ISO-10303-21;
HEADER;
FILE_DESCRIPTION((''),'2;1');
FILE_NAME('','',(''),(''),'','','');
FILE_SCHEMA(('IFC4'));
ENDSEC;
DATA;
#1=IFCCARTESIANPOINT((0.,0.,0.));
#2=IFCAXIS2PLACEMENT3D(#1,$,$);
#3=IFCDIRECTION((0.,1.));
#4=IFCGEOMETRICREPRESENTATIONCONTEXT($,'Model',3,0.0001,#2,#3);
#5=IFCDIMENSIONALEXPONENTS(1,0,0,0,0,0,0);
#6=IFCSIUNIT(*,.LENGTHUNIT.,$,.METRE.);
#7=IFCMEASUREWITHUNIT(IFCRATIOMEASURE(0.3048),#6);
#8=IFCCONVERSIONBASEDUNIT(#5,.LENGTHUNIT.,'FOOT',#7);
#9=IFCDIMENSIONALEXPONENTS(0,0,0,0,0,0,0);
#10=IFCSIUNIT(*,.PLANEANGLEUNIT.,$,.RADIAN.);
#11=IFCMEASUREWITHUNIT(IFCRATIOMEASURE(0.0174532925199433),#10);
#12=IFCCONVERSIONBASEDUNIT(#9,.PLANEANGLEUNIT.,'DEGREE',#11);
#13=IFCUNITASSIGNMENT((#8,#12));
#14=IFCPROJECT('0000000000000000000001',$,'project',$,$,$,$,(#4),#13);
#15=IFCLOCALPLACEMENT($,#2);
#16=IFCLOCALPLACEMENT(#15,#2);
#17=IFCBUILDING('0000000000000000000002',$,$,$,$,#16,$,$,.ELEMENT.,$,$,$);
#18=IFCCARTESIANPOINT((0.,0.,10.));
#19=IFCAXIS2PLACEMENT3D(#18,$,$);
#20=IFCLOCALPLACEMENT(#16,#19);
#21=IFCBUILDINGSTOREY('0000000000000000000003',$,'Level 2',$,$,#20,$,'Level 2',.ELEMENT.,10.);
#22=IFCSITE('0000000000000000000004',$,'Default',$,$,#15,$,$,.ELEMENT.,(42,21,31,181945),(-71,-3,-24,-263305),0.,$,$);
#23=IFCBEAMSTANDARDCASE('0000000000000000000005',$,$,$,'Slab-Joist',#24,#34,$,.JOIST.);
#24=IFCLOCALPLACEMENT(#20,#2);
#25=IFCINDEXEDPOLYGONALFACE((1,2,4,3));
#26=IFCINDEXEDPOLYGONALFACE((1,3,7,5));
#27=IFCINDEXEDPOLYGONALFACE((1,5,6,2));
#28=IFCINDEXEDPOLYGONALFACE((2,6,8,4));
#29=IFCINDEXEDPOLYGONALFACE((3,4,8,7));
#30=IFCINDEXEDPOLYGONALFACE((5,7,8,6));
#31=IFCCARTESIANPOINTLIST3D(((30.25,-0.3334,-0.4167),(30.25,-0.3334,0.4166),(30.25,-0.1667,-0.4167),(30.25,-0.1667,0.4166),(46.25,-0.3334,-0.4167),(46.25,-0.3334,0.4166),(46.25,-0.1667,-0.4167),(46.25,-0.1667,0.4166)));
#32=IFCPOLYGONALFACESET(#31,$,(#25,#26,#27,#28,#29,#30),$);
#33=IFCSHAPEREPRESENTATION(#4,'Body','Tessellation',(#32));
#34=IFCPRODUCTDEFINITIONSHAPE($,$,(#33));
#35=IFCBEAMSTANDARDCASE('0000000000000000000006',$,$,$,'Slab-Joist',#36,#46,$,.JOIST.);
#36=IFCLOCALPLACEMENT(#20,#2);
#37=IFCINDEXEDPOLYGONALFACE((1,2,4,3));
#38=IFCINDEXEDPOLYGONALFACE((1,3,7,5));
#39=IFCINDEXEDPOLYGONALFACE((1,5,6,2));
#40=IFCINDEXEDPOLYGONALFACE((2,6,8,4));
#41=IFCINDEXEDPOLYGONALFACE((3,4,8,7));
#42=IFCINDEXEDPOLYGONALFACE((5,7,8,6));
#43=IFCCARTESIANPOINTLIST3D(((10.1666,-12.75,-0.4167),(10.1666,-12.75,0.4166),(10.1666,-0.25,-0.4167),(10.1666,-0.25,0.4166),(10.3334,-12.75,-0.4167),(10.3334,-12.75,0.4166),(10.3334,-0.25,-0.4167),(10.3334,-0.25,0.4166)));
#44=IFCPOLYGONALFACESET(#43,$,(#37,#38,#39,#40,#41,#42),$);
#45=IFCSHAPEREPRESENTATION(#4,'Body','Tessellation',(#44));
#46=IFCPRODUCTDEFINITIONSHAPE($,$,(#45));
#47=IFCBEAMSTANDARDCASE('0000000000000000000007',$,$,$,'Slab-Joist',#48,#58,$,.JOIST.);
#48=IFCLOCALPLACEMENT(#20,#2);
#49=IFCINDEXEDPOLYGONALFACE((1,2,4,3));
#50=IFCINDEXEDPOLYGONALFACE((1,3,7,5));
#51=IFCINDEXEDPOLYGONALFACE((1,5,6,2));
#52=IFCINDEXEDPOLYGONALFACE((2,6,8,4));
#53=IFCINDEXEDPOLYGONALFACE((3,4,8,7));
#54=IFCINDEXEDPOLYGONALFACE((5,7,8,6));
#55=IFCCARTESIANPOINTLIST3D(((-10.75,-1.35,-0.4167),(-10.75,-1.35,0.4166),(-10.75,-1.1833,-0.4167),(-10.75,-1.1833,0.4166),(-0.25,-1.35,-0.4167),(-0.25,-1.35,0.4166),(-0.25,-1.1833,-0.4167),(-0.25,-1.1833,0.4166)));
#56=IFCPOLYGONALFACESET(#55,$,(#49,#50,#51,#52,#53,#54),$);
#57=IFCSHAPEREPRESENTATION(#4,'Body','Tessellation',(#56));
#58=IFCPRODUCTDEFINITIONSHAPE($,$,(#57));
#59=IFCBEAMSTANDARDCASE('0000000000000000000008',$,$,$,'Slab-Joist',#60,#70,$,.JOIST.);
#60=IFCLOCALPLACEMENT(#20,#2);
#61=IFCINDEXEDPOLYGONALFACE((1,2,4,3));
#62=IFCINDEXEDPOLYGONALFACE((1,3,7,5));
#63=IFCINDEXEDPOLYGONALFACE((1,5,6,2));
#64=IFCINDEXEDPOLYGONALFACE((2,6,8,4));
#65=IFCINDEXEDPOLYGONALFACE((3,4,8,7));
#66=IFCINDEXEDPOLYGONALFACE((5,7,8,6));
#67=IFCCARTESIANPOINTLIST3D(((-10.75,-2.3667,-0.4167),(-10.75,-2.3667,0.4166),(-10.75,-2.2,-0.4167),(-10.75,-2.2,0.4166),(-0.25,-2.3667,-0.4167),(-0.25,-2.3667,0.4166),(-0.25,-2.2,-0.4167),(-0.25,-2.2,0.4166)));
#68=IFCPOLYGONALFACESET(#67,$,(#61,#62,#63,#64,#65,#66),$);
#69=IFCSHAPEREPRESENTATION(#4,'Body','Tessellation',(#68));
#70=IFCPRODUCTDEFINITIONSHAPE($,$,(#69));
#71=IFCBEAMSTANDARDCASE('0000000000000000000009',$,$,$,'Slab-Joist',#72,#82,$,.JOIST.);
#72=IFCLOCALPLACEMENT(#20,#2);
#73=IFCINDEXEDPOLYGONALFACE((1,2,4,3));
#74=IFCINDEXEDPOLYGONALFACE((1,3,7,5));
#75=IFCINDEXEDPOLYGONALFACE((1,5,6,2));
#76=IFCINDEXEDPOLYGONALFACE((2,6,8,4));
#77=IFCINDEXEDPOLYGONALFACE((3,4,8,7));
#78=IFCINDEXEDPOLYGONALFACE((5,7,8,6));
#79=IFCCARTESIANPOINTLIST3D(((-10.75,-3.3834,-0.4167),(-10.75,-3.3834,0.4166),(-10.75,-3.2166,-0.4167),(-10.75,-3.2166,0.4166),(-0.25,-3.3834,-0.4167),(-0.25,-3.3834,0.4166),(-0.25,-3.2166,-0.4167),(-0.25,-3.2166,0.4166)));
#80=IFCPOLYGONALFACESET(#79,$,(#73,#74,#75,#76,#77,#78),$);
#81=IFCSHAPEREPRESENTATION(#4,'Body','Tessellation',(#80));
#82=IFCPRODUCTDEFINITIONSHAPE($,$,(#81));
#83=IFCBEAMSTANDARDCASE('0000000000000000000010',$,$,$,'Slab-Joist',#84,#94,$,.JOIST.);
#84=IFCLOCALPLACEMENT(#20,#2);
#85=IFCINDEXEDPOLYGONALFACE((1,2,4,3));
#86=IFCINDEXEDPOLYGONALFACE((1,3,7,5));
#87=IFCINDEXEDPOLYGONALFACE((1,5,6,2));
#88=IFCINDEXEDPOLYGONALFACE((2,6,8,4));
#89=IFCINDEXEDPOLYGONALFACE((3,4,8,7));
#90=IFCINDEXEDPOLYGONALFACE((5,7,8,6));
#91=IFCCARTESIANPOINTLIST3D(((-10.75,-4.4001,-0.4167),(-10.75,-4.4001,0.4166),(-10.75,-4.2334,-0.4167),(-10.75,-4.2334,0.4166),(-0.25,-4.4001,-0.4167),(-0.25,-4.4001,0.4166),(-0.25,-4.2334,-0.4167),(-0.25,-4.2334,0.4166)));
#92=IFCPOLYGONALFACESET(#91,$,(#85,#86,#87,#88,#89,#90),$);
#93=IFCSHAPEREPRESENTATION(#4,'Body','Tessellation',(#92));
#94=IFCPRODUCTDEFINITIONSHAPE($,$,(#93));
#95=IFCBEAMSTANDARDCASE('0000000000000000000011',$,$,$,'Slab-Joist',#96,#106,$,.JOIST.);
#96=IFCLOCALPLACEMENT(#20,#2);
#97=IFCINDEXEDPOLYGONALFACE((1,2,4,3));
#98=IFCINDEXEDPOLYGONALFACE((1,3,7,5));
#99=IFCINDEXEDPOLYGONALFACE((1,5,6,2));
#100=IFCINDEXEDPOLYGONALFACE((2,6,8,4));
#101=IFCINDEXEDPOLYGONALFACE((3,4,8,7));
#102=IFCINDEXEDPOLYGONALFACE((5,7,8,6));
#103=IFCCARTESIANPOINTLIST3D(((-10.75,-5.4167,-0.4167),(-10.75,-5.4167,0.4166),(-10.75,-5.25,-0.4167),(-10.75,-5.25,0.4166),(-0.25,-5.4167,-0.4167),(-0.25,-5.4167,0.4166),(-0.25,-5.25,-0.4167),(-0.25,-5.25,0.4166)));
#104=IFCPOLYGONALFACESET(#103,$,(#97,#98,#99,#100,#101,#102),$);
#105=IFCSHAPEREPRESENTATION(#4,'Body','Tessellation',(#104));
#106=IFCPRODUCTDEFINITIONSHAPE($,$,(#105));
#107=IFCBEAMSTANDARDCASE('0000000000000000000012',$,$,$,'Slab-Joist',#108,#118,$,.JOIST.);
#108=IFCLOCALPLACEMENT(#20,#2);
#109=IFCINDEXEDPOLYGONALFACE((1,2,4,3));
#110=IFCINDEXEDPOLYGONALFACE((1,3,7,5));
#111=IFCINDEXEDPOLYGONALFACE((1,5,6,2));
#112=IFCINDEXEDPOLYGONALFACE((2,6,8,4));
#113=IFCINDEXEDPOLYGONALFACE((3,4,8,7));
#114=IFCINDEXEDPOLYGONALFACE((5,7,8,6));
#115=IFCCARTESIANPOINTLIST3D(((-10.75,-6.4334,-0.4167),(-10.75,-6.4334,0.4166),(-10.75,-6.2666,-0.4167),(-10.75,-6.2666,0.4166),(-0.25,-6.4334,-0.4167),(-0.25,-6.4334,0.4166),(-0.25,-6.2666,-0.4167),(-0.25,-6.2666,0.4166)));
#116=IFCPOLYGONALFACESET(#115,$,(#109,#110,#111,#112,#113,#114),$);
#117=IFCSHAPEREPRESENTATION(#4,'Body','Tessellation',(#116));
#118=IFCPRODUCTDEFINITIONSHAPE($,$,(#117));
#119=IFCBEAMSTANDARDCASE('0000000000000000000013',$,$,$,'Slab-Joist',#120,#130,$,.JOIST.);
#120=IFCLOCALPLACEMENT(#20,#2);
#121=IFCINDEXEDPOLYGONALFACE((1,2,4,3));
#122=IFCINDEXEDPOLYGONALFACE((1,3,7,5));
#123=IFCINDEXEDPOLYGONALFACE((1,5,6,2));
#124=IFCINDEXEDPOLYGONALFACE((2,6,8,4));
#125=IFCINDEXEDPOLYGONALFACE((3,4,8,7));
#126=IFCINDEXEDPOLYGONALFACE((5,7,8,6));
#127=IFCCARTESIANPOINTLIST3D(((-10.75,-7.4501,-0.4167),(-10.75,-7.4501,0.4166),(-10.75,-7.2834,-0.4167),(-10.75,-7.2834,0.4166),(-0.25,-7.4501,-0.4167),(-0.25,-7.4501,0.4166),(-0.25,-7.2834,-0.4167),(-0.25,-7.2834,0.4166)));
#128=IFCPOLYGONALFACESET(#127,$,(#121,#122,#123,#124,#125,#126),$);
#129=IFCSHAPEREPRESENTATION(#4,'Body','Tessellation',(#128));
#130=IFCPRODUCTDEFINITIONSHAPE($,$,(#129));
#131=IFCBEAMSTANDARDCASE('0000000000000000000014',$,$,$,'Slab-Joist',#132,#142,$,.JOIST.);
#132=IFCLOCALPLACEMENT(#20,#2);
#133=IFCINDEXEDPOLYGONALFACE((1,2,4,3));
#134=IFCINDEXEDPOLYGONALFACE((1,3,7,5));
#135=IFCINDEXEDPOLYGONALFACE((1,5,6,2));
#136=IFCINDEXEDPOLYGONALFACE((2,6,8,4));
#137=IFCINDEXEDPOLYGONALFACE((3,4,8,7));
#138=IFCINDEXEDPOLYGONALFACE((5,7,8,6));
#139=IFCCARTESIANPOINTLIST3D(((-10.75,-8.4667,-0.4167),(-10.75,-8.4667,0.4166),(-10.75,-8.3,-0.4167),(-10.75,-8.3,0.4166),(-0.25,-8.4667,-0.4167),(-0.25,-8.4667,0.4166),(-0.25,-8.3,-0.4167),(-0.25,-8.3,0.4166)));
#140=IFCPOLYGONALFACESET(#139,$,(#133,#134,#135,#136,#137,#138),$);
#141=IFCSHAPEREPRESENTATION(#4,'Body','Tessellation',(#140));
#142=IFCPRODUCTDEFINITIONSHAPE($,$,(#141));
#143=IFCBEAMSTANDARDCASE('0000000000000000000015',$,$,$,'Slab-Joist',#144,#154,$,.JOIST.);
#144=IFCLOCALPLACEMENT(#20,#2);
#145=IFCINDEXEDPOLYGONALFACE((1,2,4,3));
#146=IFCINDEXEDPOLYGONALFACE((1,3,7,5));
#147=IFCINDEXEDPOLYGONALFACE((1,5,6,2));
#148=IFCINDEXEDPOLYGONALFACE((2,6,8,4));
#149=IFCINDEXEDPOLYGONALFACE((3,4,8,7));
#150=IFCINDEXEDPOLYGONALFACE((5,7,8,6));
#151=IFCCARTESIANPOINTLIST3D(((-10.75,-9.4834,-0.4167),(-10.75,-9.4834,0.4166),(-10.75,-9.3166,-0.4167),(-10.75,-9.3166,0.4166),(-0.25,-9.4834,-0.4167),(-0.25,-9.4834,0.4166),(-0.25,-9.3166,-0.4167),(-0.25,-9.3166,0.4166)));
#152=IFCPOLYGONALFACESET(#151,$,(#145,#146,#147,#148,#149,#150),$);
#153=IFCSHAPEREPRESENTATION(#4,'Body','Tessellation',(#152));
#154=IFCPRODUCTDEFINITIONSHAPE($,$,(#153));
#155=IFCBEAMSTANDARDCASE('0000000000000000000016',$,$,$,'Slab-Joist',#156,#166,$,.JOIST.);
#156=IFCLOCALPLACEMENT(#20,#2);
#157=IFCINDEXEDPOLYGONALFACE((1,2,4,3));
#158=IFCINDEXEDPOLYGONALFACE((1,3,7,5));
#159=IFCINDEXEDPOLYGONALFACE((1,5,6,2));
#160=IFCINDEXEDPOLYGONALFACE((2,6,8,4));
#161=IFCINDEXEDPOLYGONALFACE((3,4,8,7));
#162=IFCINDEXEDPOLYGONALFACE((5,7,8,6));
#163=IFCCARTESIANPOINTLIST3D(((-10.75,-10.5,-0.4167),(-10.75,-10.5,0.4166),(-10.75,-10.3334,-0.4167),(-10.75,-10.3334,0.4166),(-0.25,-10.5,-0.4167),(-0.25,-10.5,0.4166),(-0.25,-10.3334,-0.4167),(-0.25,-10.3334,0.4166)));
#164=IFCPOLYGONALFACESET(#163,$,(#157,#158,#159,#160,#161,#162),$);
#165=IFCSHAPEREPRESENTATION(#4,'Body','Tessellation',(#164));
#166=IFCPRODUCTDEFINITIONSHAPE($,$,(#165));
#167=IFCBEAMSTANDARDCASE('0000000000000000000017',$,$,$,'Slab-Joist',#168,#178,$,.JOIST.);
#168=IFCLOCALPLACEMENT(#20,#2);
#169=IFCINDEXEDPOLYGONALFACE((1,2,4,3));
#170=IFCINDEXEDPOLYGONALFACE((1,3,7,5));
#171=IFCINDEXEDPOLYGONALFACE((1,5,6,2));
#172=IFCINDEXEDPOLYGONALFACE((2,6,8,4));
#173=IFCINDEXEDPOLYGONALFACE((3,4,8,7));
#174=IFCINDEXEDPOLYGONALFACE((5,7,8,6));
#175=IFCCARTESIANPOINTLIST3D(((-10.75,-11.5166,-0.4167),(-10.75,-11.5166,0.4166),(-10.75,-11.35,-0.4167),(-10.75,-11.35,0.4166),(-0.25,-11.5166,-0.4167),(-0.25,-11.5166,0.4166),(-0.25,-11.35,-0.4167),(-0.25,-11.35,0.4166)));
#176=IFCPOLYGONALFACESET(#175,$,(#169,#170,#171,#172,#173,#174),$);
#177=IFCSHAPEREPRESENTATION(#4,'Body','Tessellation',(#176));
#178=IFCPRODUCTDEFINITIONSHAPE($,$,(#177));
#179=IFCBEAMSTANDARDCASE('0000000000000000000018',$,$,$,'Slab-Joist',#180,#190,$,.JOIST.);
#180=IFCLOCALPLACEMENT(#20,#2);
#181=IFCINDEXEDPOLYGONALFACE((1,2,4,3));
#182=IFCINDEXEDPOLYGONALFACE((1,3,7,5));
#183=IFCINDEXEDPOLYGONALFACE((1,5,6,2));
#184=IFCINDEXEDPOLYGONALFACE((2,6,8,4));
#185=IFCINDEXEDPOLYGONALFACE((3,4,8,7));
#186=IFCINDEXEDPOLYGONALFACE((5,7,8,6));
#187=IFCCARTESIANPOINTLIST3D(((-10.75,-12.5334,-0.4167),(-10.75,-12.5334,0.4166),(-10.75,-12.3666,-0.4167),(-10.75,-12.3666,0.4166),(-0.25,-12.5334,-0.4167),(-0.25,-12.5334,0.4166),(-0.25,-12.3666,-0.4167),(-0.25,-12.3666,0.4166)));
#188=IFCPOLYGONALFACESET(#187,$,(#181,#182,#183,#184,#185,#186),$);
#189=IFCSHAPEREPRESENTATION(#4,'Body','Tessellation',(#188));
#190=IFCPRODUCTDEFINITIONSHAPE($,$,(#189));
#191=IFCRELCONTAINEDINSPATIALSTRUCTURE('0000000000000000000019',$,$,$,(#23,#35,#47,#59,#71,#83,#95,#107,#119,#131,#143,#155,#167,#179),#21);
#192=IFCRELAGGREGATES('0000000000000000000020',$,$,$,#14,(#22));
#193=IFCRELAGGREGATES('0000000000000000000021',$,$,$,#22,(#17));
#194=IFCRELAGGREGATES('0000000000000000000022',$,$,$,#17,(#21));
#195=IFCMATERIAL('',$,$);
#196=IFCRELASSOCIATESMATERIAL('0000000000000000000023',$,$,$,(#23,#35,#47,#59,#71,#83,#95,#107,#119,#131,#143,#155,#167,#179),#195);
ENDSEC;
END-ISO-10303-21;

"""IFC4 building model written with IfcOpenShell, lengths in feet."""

from ifc_helpers import new_model, entity, si_unit, converted_unit, direction, frame, origin, origin_with_axes, place, context, project, spatial, rectangle, extrude, material, element, save


model = new_model("IFC4")

# Units and contexts
model_context = context("Model", 3, precision=0.0001, world=origin(), true_north=direction((0.0, 1.0)))
ifc_project = project(units=[converted_unit("LENGTHUNIT", "FOOT", entity("IfcRatioMeasure", 0.3048), si_unit("LENGTHUNIT", "METRE"), dimensions=[1, 0, 0, 0, 0, 0, 0]), converted_unit("PLANEANGLEUNIT", "DEGREE", entity("IfcRatioMeasure", 0.0174532925199433), si_unit("PLANEANGLEUNIT", "RADIAN"), dimensions=[0, 0, 0, 0, 0, 0, 0])], contexts=[model_context])

# Site, building, storey
site_placement = place(None, origin())
site = spatial("IfcSite", under=ifc_project, at=site_placement, Name="Default", CompositionType="ELEMENT", RefLatitude=(42, 21, 31, 181945), RefLongitude=(-71, -3, -24, -263305), RefElevation=0.0)
building_placement = place(site_placement, origin())
building = spatial("IfcBuilding", under=site, at=building_placement, CompositionType="ELEMENT")
storey_placement = place(building_placement, frame((0.0, 0.0, 10.0)))
storey = spatial("IfcBuildingStorey", under=building, at=storey_placement, Name="Level 2", LongName="Level 2", CompositionType="ELEMENT", Elevation=10.0)

# Beams
ifc_material = material(Name="")
placement_1 = place(storey_placement, frame((30.25, -0.25, 0.0), z_axis=(0.0, 0.0, 1.0), x_axis=(1.0, 0.0, 0.0)))
beam_1_placement = place(placement_1, frame((0.0, 0.0, 0.0), z_axis=(1.0, 0.0, 0.0), x_axis=(0.0, 1.0, 0.0)))
element("IfcBeamStandardCase", 1, at=beam_1_placement, inside=storey, material=ifc_material, ObjectType="Slab-Joist", PredefinedType="JOIST", context=model_context, shape_type="SweptSolid", body=[
    extrude(rectangle(XDim=0.1667, YDim=0.8333), origin_with_axes(), (0.0, 0.0, 1.0), 16.0),
])
placement_2 = place(storey_placement, frame((10.25, -0.25, 0.0), z_axis=(0.0, 0.0, 1.0), x_axis=(1.0, 0.0, 0.0)))
beam_2_placement = place(placement_2, frame((0.0, 0.0, 0.0), z_axis=(0.0, -1.0, 0.0), x_axis=(1.0, 0.0, 0.0)))
element("IfcBeamStandardCase", 2, at=beam_2_placement, inside=storey, material=ifc_material, ObjectType="Slab-Joist", PredefinedType="JOIST", context=model_context, shape_type="SweptSolid", body=[
    extrude(rectangle(XDim=0.1667, YDim=0.8333), origin_with_axes(), (0.0, 0.0, 1.0), 12.5),
])
placement_3 = place(storey_placement, frame((-0.25, -0.25, 0.0), z_axis=(0.0, 0.0, 1.0), x_axis=(1.0, 0.0, 0.0)))
beam_3_placement = place(placement_3, frame((0.0, -1.0167, 0.0), z_axis=(-1.0, 0.0, 0.0), x_axis=(0.0, -1.0, 0.0)))
element("IfcBeamStandardCase", 3, at=beam_3_placement, inside=storey, material=ifc_material, ObjectType="Slab-Joist", PredefinedType="JOIST", context=model_context, shape_type="SweptSolid", body=[
    extrude(rectangle(XDim=0.1667, YDim=0.8333), origin_with_axes(), (0.0, 0.0, 1.0), 10.5),
])
placement_4 = place(storey_placement, frame((-0.25, -0.25, 0.0), z_axis=(0.0, 0.0, 1.0), x_axis=(1.0, 0.0, 0.0)))
beam_4_placement = place(placement_4, frame((0.0, -2.0333, 0.0), z_axis=(-1.0, 0.0, 0.0), x_axis=(0.0, -1.0, 0.0)))
element("IfcBeamStandardCase", 4, at=beam_4_placement, inside=storey, material=ifc_material, ObjectType="Slab-Joist", PredefinedType="JOIST", context=model_context, shape_type="SweptSolid", body=[
    extrude(rectangle(XDim=0.1667, YDim=0.8333), origin_with_axes(), (0.0, 0.0, 1.0), 10.5),
])
placement_5 = place(storey_placement, frame((-0.25, -0.25, 0.0), z_axis=(0.0, 0.0, 1.0), x_axis=(1.0, 0.0, 0.0)))
beam_5_placement = place(placement_5, frame((0.0, -3.05, 0.0), z_axis=(-1.0, 0.0, 0.0), x_axis=(0.0, -1.0, 0.0)))
element("IfcBeamStandardCase", 5, at=beam_5_placement, inside=storey, material=ifc_material, ObjectType="Slab-Joist", PredefinedType="JOIST", context=model_context, shape_type="SweptSolid", body=[
    extrude(rectangle(XDim=0.1667, YDim=0.8333), origin_with_axes(), (0.0, 0.0, 1.0), 10.5),
])
placement_6 = place(storey_placement, frame((-0.25, -0.25, 0.0), z_axis=(0.0, 0.0, 1.0), x_axis=(1.0, 0.0, 0.0)))
beam_6_placement = place(placement_6, frame((0.0, -4.0667, 0.0), z_axis=(-1.0, 0.0, 0.0), x_axis=(0.0, -1.0, 0.0)))
element("IfcBeamStandardCase", 6, at=beam_6_placement, inside=storey, material=ifc_material, ObjectType="Slab-Joist", PredefinedType="JOIST", context=model_context, shape_type="SweptSolid", body=[
    extrude(rectangle(XDim=0.1667, YDim=0.8333), origin_with_axes(), (0.0, 0.0, 1.0), 10.5),
])
placement_7 = place(storey_placement, frame((-0.25, -0.25, 0.0), z_axis=(0.0, 0.0, 1.0), x_axis=(1.0, 0.0, 0.0)))
beam_7_placement = place(placement_7, frame((0.0, -5.0833, 0.0), z_axis=(-1.0, 0.0, 0.0), x_axis=(0.0, -1.0, 0.0)))
element("IfcBeamStandardCase", 7, at=beam_7_placement, inside=storey, material=ifc_material, ObjectType="Slab-Joist", PredefinedType="JOIST", context=model_context, shape_type="SweptSolid", body=[
    extrude(rectangle(XDim=0.1667, YDim=0.8333), origin_with_axes(), (0.0, 0.0, 1.0), 10.5),
])
placement_8 = place(storey_placement, frame((-0.25, -0.25, 0.0), z_axis=(0.0, 0.0, 1.0), x_axis=(1.0, 0.0, 0.0)))
beam_8_placement = place(placement_8, frame((0.0, -6.1, 0.0), z_axis=(-1.0, 0.0, 0.0), x_axis=(0.0, -1.0, 0.0)))
element("IfcBeamStandardCase", 8, at=beam_8_placement, inside=storey, material=ifc_material, ObjectType="Slab-Joist", PredefinedType="JOIST", context=model_context, shape_type="SweptSolid", body=[
    extrude(rectangle(XDim=0.1667, YDim=0.8333), origin_with_axes(), (0.0, 0.0, 1.0), 10.5),
])
placement_9 = place(storey_placement, frame((-0.25, -0.25, 0.0), z_axis=(0.0, 0.0, 1.0), x_axis=(1.0, 0.0, 0.0)))
beam_9_placement = place(placement_9, frame((0.0, -7.1167, 0.0), z_axis=(-1.0, 0.0, 0.0), x_axis=(0.0, -1.0, 0.0)))
element("IfcBeamStandardCase", 9, at=beam_9_placement, inside=storey, material=ifc_material, ObjectType="Slab-Joist", PredefinedType="JOIST", context=model_context, shape_type="SweptSolid", body=[
    extrude(rectangle(XDim=0.1667, YDim=0.8333), origin_with_axes(), (0.0, 0.0, 1.0), 10.5),
])
placement_10 = place(storey_placement, frame((-0.25, -0.25, 0.0), z_axis=(0.0, 0.0, 1.0), x_axis=(1.0, 0.0, 0.0)))
beam_10_placement = place(placement_10, frame((0.0, -8.1333, 0.0), z_axis=(-1.0, 0.0, 0.0), x_axis=(0.0, -1.0, 0.0)))
element("IfcBeamStandardCase", 10, at=beam_10_placement, inside=storey, material=ifc_material, ObjectType="Slab-Joist", PredefinedType="JOIST", context=model_context, shape_type="SweptSolid", body=[
    extrude(rectangle(XDim=0.1667, YDim=0.8333), origin_with_axes(), (0.0, 0.0, 1.0), 10.5),
])
placement_11 = place(storey_placement, frame((-0.25, -0.25, 0.0), z_axis=(0.0, 0.0, 1.0), x_axis=(1.0, 0.0, 0.0)))
beam_11_placement = place(placement_11, frame((0.0, -9.15, 0.0), z_axis=(-1.0, 0.0, 0.0), x_axis=(0.0, -1.0, 0.0)))
element("IfcBeamStandardCase", 11, at=beam_11_placement, inside=storey, material=ifc_material, ObjectType="Slab-Joist", PredefinedType="JOIST", context=model_context, shape_type="SweptSolid", body=[
    extrude(rectangle(XDim=0.1667, YDim=0.8333), origin_with_axes(), (0.0, 0.0, 1.0), 10.5),
])
placement_12 = place(storey_placement, frame((-0.25, -0.25, 0.0), z_axis=(0.0, 0.0, 1.0), x_axis=(1.0, 0.0, 0.0)))
beam_12_placement = place(placement_12, frame((0.0, -10.1667, 0.0), z_axis=(-1.0, 0.0, 0.0), x_axis=(0.0, -1.0, 0.0)))
element("IfcBeamStandardCase", 12, at=beam_12_placement, inside=storey, material=ifc_material, ObjectType="Slab-Joist", PredefinedType="JOIST", context=model_context, shape_type="SweptSolid", body=[
    extrude(rectangle(XDim=0.1667, YDim=0.8333), origin_with_axes(), (0.0, 0.0, 1.0), 10.5),
])
placement_13 = place(storey_placement, frame((-0.25, -0.25, 0.0), z_axis=(0.0, 0.0, 1.0), x_axis=(1.0, 0.0, 0.0)))
beam_13_placement = place(placement_13, frame((0.0, -11.1833, 0.0), z_axis=(-1.0, 0.0, 0.0), x_axis=(0.0, -1.0, 0.0)))
element("IfcBeamStandardCase", 13, at=beam_13_placement, inside=storey, material=ifc_material, ObjectType="Slab-Joist", PredefinedType="JOIST", context=model_context, shape_type="SweptSolid", body=[
    extrude(rectangle(XDim=0.1667, YDim=0.8333), origin_with_axes(), (0.0, 0.0, 1.0), 10.5),
])
placement_14 = place(storey_placement, frame((-0.25, -0.25, 0.0), z_axis=(0.0, 0.0, 1.0), x_axis=(1.0, 0.0, 0.0)))
beam_14_placement = place(placement_14, frame((0.0, -12.2, 0.0), z_axis=(-1.0, 0.0, 0.0), x_axis=(0.0, -1.0, 0.0)))
element("IfcBeamStandardCase", 14, at=beam_14_placement, inside=storey, material=ifc_material, ObjectType="Slab-Joist", PredefinedType="JOIST", context=model_context, shape_type="SweptSolid", body=[
    extrude(rectangle(XDim=0.1667, YDim=0.8333), origin_with_axes(), (0.0, 0.0, 1.0), 10.5),
])

save(model, "model.ifc")
